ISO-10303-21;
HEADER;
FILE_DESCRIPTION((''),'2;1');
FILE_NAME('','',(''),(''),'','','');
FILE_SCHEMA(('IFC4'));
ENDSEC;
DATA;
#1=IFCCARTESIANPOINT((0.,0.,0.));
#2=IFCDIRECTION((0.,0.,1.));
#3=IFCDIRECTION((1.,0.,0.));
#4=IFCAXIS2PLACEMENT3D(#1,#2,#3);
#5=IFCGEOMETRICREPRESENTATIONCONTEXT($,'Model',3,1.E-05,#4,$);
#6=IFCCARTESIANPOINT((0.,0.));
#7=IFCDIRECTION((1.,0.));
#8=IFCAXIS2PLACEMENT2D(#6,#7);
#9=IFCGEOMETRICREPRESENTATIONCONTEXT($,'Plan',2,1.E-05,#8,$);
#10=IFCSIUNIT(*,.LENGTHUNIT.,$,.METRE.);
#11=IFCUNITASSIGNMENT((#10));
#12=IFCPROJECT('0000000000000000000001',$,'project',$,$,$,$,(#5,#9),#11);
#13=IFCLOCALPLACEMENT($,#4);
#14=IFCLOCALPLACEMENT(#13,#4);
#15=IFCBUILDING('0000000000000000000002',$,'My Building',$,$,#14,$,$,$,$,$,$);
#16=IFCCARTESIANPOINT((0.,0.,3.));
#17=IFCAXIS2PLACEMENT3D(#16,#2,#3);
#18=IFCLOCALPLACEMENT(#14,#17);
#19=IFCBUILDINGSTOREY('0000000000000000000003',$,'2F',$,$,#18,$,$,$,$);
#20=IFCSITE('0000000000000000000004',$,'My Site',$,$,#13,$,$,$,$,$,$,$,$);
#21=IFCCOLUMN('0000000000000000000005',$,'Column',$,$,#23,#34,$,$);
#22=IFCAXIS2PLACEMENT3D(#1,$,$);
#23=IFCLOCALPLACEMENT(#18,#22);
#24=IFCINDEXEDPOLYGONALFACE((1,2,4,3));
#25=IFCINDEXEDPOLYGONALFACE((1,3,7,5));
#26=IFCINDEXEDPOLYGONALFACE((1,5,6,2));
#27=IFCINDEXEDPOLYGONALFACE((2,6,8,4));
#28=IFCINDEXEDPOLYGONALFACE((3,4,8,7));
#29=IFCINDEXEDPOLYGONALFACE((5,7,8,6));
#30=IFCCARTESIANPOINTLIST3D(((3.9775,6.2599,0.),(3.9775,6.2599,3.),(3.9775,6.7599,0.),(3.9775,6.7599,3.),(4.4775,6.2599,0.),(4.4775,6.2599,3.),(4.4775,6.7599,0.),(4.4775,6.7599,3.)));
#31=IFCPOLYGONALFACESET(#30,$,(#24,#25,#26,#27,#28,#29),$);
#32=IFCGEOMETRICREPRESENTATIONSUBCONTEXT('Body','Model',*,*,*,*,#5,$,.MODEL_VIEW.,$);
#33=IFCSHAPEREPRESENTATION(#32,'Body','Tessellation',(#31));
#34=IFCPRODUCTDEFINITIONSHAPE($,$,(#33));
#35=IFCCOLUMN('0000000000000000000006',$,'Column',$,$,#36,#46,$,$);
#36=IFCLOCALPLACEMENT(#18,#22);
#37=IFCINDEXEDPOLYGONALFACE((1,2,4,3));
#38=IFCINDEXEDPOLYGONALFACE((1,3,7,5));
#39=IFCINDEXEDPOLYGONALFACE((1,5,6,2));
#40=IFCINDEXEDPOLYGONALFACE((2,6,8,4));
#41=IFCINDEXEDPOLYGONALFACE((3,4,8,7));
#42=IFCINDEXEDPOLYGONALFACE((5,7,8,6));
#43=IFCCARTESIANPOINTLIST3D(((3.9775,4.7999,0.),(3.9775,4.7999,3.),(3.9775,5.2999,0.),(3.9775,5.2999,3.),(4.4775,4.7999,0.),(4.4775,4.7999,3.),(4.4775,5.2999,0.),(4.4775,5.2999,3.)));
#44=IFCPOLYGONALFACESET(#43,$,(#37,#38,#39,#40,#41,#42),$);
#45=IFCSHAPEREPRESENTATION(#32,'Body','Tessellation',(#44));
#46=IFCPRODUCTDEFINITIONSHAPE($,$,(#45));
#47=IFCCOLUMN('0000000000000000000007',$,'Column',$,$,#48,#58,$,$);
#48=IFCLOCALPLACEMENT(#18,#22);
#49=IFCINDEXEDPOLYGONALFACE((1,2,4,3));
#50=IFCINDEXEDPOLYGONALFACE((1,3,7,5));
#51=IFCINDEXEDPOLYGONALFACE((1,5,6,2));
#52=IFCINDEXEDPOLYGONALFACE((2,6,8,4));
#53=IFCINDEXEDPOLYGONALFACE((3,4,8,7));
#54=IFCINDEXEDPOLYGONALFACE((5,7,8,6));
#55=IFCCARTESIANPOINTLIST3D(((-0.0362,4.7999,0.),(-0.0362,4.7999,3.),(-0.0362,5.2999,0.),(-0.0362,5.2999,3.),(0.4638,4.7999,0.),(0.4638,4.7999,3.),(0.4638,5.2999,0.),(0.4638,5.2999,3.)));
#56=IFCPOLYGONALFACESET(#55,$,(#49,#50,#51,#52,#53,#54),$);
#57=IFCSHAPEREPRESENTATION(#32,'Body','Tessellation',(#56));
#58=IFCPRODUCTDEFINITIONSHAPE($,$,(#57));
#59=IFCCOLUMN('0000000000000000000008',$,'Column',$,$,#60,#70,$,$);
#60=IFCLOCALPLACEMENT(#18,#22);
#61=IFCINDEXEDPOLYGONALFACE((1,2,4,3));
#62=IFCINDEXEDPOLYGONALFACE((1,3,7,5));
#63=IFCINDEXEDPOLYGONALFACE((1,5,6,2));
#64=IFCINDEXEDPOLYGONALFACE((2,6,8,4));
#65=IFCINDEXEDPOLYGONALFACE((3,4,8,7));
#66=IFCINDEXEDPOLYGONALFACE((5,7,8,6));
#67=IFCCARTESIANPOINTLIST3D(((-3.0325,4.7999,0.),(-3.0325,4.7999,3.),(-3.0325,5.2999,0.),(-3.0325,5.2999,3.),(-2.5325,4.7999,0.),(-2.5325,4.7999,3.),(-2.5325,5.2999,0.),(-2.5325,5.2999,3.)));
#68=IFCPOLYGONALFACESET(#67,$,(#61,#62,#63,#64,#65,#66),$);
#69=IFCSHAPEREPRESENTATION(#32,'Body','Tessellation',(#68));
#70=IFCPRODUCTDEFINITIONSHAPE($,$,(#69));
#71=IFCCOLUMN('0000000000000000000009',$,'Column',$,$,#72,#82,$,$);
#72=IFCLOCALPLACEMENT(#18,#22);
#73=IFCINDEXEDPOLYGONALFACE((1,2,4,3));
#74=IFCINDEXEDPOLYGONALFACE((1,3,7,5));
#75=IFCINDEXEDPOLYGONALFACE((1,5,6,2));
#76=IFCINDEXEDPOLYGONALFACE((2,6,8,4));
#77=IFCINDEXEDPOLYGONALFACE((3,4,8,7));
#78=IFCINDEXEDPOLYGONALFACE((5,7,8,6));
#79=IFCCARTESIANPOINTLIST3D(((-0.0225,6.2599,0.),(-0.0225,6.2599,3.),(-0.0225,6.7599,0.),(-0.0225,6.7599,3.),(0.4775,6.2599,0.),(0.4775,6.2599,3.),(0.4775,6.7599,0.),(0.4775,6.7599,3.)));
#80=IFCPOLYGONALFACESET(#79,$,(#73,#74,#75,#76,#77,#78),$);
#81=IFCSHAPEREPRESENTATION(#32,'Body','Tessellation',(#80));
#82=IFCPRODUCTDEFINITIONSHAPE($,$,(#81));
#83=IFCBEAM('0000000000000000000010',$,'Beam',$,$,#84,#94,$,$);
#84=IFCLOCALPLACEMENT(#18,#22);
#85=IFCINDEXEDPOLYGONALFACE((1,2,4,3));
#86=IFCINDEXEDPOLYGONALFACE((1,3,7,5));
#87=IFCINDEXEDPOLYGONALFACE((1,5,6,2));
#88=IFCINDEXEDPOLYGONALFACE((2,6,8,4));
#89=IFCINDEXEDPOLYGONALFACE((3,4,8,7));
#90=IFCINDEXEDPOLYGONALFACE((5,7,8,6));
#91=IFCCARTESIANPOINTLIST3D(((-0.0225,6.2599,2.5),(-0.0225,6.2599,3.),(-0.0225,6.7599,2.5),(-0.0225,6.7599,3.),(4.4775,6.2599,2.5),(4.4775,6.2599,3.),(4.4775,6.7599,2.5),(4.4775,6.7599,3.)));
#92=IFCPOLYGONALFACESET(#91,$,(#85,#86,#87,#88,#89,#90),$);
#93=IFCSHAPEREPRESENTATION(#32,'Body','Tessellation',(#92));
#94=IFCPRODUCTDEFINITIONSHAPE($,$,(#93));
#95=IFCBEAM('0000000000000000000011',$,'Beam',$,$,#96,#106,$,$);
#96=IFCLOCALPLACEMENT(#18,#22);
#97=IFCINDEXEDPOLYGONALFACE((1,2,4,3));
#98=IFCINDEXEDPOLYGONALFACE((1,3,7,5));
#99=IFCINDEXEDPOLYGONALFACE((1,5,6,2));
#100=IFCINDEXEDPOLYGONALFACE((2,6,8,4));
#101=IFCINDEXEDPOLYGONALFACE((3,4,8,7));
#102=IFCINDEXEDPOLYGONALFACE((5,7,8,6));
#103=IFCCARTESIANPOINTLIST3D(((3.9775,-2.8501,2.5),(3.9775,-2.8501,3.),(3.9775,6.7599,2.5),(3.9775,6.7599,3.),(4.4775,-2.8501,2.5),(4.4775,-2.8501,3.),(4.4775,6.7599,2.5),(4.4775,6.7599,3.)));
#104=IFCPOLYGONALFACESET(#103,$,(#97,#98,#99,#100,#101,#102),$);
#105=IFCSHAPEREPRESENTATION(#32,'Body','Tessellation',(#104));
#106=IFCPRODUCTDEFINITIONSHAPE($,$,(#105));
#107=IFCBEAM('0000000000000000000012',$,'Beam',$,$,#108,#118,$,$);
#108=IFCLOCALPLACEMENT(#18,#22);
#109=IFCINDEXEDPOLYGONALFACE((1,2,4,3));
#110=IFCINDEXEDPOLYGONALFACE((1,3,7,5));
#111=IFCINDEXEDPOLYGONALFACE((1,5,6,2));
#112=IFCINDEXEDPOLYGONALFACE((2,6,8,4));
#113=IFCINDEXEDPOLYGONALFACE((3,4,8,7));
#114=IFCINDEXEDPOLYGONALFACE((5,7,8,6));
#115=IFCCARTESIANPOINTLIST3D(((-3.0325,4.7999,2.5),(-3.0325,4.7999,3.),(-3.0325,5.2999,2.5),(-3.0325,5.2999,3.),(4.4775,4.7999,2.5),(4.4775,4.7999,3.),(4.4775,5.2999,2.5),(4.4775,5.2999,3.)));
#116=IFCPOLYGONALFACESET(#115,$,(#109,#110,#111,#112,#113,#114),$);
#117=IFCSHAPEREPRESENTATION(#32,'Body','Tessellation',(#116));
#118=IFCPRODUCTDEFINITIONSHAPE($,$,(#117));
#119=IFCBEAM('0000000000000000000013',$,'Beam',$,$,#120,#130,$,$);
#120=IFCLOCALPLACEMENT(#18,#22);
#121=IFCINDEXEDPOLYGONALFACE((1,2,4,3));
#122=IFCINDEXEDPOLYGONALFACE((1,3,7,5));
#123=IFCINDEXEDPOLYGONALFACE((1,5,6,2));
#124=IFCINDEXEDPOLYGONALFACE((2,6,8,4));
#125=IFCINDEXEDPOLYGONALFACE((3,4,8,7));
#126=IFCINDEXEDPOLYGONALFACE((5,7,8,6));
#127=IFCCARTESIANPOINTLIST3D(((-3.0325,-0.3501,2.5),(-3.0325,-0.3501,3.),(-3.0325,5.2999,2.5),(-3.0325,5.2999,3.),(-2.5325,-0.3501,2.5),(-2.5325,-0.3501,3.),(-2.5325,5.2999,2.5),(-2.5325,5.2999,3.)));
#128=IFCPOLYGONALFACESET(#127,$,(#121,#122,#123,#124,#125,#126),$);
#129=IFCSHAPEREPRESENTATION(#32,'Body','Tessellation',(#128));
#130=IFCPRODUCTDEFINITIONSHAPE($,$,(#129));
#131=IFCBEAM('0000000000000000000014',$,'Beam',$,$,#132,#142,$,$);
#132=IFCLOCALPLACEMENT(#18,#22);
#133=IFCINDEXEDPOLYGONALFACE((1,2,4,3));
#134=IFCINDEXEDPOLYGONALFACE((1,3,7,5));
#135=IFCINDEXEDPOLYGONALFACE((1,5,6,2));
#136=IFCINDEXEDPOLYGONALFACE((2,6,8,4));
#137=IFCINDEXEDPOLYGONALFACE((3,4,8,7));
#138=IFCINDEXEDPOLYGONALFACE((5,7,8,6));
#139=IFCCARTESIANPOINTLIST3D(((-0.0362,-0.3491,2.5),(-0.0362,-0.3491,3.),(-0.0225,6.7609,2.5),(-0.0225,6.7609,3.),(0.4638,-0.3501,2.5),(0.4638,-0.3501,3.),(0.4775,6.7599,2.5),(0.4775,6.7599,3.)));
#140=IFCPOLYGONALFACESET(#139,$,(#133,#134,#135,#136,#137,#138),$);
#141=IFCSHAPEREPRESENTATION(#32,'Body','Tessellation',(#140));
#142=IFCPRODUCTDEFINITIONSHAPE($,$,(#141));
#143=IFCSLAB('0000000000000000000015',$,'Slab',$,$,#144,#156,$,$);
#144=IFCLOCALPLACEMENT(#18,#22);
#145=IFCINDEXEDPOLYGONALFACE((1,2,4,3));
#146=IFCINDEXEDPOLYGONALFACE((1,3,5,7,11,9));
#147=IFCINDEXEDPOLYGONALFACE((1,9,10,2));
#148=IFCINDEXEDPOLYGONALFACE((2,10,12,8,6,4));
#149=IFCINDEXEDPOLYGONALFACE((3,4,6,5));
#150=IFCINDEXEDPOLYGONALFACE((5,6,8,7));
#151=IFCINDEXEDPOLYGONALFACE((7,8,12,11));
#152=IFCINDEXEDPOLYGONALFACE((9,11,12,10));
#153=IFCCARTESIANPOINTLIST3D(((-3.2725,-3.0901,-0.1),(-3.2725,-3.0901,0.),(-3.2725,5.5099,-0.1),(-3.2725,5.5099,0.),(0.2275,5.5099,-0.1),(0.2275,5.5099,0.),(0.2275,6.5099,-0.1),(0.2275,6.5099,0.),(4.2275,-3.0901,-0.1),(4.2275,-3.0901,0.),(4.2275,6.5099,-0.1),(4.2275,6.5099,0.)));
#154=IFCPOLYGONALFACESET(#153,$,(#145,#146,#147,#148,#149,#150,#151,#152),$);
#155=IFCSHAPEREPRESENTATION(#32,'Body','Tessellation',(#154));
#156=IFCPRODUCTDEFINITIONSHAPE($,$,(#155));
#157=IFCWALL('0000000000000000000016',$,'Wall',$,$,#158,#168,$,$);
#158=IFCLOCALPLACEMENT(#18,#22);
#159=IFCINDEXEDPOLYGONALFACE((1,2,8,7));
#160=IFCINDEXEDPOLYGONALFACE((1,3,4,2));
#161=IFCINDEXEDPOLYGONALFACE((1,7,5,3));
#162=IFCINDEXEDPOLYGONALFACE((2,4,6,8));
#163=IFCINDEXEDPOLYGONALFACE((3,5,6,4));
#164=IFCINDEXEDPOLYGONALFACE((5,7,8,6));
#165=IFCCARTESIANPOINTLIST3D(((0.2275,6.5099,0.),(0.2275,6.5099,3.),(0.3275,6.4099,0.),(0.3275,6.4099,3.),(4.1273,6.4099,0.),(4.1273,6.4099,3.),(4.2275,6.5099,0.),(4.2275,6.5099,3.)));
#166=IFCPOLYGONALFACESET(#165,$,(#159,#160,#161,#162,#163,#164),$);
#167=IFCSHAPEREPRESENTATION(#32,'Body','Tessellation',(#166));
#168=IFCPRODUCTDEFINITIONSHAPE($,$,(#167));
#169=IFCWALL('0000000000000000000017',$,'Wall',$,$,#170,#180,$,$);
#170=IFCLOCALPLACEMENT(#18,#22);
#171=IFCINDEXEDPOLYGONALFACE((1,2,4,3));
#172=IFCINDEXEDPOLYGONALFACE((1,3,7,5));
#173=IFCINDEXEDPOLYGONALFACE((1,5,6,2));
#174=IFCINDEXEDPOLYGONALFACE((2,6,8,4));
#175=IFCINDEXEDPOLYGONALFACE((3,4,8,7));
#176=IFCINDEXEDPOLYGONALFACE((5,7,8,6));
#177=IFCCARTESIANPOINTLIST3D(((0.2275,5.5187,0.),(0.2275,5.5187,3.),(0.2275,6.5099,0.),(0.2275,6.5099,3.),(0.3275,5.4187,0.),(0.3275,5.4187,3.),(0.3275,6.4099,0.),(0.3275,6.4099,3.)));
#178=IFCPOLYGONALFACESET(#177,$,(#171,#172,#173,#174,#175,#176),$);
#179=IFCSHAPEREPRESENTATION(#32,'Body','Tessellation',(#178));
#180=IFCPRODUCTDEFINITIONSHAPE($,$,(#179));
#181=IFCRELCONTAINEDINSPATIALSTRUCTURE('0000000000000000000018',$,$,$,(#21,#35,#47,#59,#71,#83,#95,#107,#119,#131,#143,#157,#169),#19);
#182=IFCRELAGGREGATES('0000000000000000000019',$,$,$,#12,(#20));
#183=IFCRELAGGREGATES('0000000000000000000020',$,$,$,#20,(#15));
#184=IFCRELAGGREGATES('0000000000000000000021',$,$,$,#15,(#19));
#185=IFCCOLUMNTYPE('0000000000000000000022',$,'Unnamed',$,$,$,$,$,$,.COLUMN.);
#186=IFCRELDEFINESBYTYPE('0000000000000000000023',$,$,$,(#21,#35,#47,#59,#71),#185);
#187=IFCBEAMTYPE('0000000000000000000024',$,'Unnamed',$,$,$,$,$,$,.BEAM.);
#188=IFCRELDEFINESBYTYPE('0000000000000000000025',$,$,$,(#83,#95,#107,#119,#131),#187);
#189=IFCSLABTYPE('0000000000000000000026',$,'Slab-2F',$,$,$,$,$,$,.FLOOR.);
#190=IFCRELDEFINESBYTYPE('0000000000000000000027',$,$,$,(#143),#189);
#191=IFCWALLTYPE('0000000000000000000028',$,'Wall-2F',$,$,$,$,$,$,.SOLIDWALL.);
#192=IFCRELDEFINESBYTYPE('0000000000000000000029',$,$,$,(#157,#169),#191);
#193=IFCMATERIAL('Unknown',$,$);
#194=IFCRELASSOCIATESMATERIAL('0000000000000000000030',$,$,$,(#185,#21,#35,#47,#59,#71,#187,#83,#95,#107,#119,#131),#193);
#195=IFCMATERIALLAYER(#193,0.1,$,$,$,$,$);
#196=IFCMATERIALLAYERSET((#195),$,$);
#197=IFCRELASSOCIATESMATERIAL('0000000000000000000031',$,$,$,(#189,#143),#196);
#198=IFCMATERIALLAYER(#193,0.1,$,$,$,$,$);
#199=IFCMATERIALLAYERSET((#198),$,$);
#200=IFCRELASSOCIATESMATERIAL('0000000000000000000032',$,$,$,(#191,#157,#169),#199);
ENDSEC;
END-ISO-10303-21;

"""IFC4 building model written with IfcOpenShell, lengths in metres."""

from ifc_helpers import new_model, si_unit, frame, origin_with_axes, origin_2d_with_axis, place, context, subcontext, project, spatial, line, indexed_curve, rectangle, outline, extrude, material, layer, layer_set, layer_usage, material_profile, profile_set, profile_usage, type_object, element, save


model = new_model("IFC4")

# Units and contexts
model_context = context("Model", 3, precision=1e-05, world=origin_with_axes())
plan_context = context("Plan", 2, precision=1e-05, world=origin_2d_with_axis())
body_context_1 = subcontext(model_context, "Body", "Model", "MODEL_VIEW")
ifc_project = project(units=[si_unit("LENGTHUNIT", "METRE")], contexts=[model_context, plan_context])

# Site, building, storey
site_placement = place(None, origin_with_axes())
site = spatial("IfcSite", under=ifc_project, at=site_placement, Name="My Site")
building_placement = place(site_placement, origin_with_axes())
building = spatial("IfcBuilding", under=site, at=building_placement, Name="My Building")
storey_placement = place(building_placement, frame((0.0, 0.0, 3.0), z_axis=(0.0, 0.0, 1.0), x_axis=(1.0, 0.0, 0.0)))
storey = spatial("IfcBuildingStorey", under=building, at=storey_placement, Name="2F")

# Columns
ifc_material_1 = material(Name="Unknown")
ifc_material_profile_1 = material_profile(ifc_material_1, rectangle(XDim=0.5, YDim=0.5))
ifc_profile_set_1 = profile_set([ifc_material_profile_1])
ifc_profile_usage_1 = profile_usage(ifc_profile_set_1, cardinal=5)
column_type = type_object("IfcColumnType", Name="Unnamed", PredefinedType="COLUMN", material=ifc_profile_set_1)
column_1_placement = place(storey_placement, frame((4.2275, 6.5099, 0.0), z_axis=(0.0, 0.0, 1.0), x_axis=(1.0, 0.0, 0.0)))
element("IfcColumn", 1, at=column_1_placement, inside=storey, type_object=column_type, material=ifc_profile_usage_1, Name="Column", context=body_context_1, shape_type="SweptSolid", body=[
    extrude(rectangle(XDim=0.5, YDim=0.5), origin_with_axes(), (0.0, 0.0, 1.0), 3.0),
])
ifc_profile_usage_2 = profile_usage(ifc_profile_set_1, cardinal=5)
column_2_placement = place(storey_placement, frame((4.2275, 5.0499, 0.0), z_axis=(0.0, 0.0, 1.0), x_axis=(1.0, 0.0, 0.0)))
element("IfcColumn", 2, at=column_2_placement, inside=storey, type_object=column_type, material=ifc_profile_usage_2, Name="Column", context=body_context_1, shape_type="SweptSolid", body=[
    extrude(rectangle(XDim=0.5, YDim=0.5), origin_with_axes(), (0.0, 0.0, 1.0), 3.0),
])
ifc_profile_usage_3 = profile_usage(ifc_profile_set_1, cardinal=5)
column_3_placement = place(storey_placement, frame((0.2138, 5.0499, 0.0), z_axis=(0.0, 0.0, 1.0), x_axis=(1.0, 0.0, 0.0)))
element("IfcColumn", 3, at=column_3_placement, inside=storey, type_object=column_type, material=ifc_profile_usage_3, Name="Column", context=body_context_1, shape_type="SweptSolid", body=[
    extrude(rectangle(XDim=0.5, YDim=0.5), origin_with_axes(), (0.0, 0.0, 1.0), 3.0),
])
ifc_profile_usage_4 = profile_usage(ifc_profile_set_1, cardinal=5)
column_4_placement = place(storey_placement, frame((-2.7825, 5.0499, 0.0), z_axis=(0.0, 0.0, 1.0), x_axis=(1.0, 0.0, 0.0)))
element("IfcColumn", 4, at=column_4_placement, inside=storey, type_object=column_type, material=ifc_profile_usage_4, Name="Column", context=body_context_1, shape_type="SweptSolid", body=[
    extrude(rectangle(XDim=0.5, YDim=0.5), origin_with_axes(), (0.0, 0.0, 1.0), 3.0),
])
ifc_profile_usage_5 = profile_usage(ifc_profile_set_1, cardinal=5)
column_5_placement = place(storey_placement, frame((0.2275, 6.5099, 0.0), z_axis=(0.0, 0.0, 1.0), x_axis=(1.0, 0.0, 0.0)))
element("IfcColumn", 5, at=column_5_placement, inside=storey, type_object=column_type, material=ifc_profile_usage_5, Name="Column", context=body_context_1, shape_type="SweptSolid", body=[
    extrude(rectangle(XDim=0.5, YDim=0.5), origin_with_axes(), (0.0, 0.0, 1.0), 3.0),
])

# Beams
ifc_material_profile_2 = material_profile(ifc_material_1, rectangle(XDim=0.5, YDim=0.5))
ifc_profile_set_2 = profile_set([ifc_material_profile_2])
ifc_profile_usage_6 = profile_usage(ifc_profile_set_2, cardinal=7)
beam_type = type_object("IfcBeamType", Name="Unnamed", PredefinedType="BEAM", material=ifc_profile_set_2)
beam_1_placement = place(storey_placement, frame((4.4775, 6.2599, 3.0), z_axis=(-1.0, 0.0, 0.0), x_axis=(0.0, -1.0, 0.0)))
element("IfcBeam", 6, at=beam_1_placement, inside=storey, type_object=beam_type, material=ifc_profile_usage_6, Name="Beam", context=body_context_1, shape_type="SweptSolid", body=[
    extrude(rectangle(XDim=0.5, YDim=0.5), frame((-0.25, -0.25, 0.0), z_axis=(0.0, 0.0, 1.0), x_axis=(1.0, 0.0, 0.0)), (0.0, 0.0, 1.0), 4.5),
])
ifc_profile_usage_7 = profile_usage(ifc_profile_set_2, cardinal=7)
beam_2_placement = place(storey_placement, frame((4.4775, 6.7599, 3.0), z_axis=(0.0, -1.0, 0.0), x_axis=(1.0, 0.0, 0.0)))
element("IfcBeam", 7, at=beam_2_placement, inside=storey, type_object=beam_type, material=ifc_profile_usage_7, Name="Beam", context=body_context_1, shape_type="SweptSolid", body=[
    extrude(rectangle(XDim=0.5, YDim=0.5), frame((-0.25, -0.25, 0.0), z_axis=(0.0, 0.0, 1.0), x_axis=(1.0, 0.0, 0.0)), (0.0, 0.0, 1.0), 9.61),
])
ifc_profile_usage_8 = profile_usage(ifc_profile_set_2, cardinal=7)
beam_3_placement = place(storey_placement, frame((4.4775, 4.7999, 3.0), z_axis=(-1.0, 0.0, 0.0), x_axis=(0.0, -1.0, 0.0)))
element("IfcBeam", 8, at=beam_3_placement, inside=storey, type_object=beam_type, material=ifc_profile_usage_8, Name="Beam", context=body_context_1, shape_type="SweptSolid", body=[
    extrude(rectangle(XDim=0.5, YDim=0.5), frame((-0.25, -0.25, 0.0), z_axis=(0.0, 0.0, 1.0), x_axis=(1.0, 0.0, 0.0)), (0.0, 0.0, 1.0), 7.51),
])
ifc_profile_usage_9 = profile_usage(ifc_profile_set_2, cardinal=7)
beam_4_placement = place(storey_placement, frame((-2.5325, 5.2999, 3.0), z_axis=(0.0, -1.0, 0.0), x_axis=(1.0, 0.0, 0.0)))
element("IfcBeam", 9, at=beam_4_placement, inside=storey, type_object=beam_type, material=ifc_profile_usage_9, Name="Beam", context=body_context_1, shape_type="SweptSolid", body=[
    extrude(rectangle(XDim=0.5, YDim=0.5), frame((-0.25, -0.25, 0.0), z_axis=(0.0, 0.0, 1.0), x_axis=(1.0, 0.0, 0.0)), (0.0, 0.0, 1.0), 5.65),
])
ifc_profile_usage_10 = profile_usage(ifc_profile_set_2, cardinal=7)
beam_5_placement = place(storey_placement, frame((0.4775, 6.7599, 3.0), z_axis=(-0.00192, -0.999998, 0.0), x_axis=(0.999998, -0.00192, 0.0)))
element("IfcBeam", 10, at=beam_5_placement, inside=storey, type_object=beam_type, material=ifc_profile_usage_10, Name="Beam", context=body_context_1, shape_type="SweptSolid", body=[
    extrude(rectangle(XDim=0.5, YDim=0.5), frame((-0.25, -0.25, 0.0), z_axis=(0.0, 0.0, 1.0), x_axis=(1.0, 0.0, 0.0)), (0.0, 0.0, 1.0), 7.11),
])

# Slab
ifc_layer_1 = layer(ifc_material_1, 0.1)
ifc_layer_set_1 = layer_set([ifc_layer_1])
ifc_layer_usage_1 = layer_usage(ifc_layer_set_1, "AXIS3", "POSITIVE", -0.1)
slab_type = type_object("IfcSlabType", Name="Slab-2F", PredefinedType="FLOOR", material=ifc_layer_set_1)
slab_placement = place(storey_placement, frame((4.2275, 6.5099, 0.0), z_axis=(0.0, 0.0, 1.0), x_axis=(1.0, 0.0, 0.0)))
element("IfcSlab", 11, at=slab_placement, inside=storey, type_object=slab_type, material=ifc_layer_usage_1, Name="Slab", context=body_context_1, shape_type="SweptSolid", body=[
    extrude(outline(indexed_curve([(0.0, 0.0), (-4.0, 0.0), (-4.0, -1.0), (-7.5, -1.0), (-7.5, -9.6), (0.0, -9.6), (0.0, 0.0)])), frame((0.0, 0.0, -0.1), z_axis=(0.0, 0.0, 1.0), x_axis=(1.0, 0.0, 0.0)), (0.0, 0.0, 1.0), 0.1),
])

# Walls
ifc_layer_2 = layer(ifc_material_1, 0.1)
ifc_layer_set_2 = layer_set([ifc_layer_2])
ifc_layer_usage_2 = layer_usage(ifc_layer_set_2, "AXIS2", "POSITIVE", 0.0)
wall_type = type_object("IfcWallType", Name="Wall-2F", PredefinedType="SOLIDWALL", material=ifc_layer_set_2)
wall_1_placement = place(storey_placement, frame((4.2275, 6.5099, 0.0), z_axis=(0.0, 0.0, 1.0), x_axis=(-1.0, 0.0, 0.0)))
element("IfcWall", 12, at=wall_1_placement, inside=storey, type_object=wall_type, material=ifc_layer_usage_2, Name="Wall", context=body_context_1, shape_type="SweptSolid", body=[
    extrude(outline(indexed_curve([(0.0, 0.0), (0.1002, 0.1), (3.9, 0.1), (4.0, 0.0)], segments=[line(1, 2, 3, 4, 1)])), origin_with_axes(), (0.0, 0.0, 1.0), 3.0),
])
ifc_layer_usage_3 = layer_usage(ifc_layer_set_2, "AXIS2", "POSITIVE", 0.0)
wall_2_placement = place(storey_placement, frame((0.2275, 6.5099, 0.0), z_axis=(0.0, 0.0, 1.0), x_axis=(0.0, -1.0, 0.0)))
element("IfcWall", 13, at=wall_2_placement, inside=storey, type_object=wall_type, material=ifc_layer_usage_3, Name="Wall", context=body_context_1, shape_type="SweptSolid", body=[
    extrude(outline(indexed_curve([(0.0, 0.0), (0.1, 0.1), (1.0913, 0.1), (0.9913, 0.0)], segments=[line(1, 2, 3, 4, 1)])), origin_with_axes(), (0.0, 0.0, 1.0), 3.0),
])

save(model, "model.ifc")
